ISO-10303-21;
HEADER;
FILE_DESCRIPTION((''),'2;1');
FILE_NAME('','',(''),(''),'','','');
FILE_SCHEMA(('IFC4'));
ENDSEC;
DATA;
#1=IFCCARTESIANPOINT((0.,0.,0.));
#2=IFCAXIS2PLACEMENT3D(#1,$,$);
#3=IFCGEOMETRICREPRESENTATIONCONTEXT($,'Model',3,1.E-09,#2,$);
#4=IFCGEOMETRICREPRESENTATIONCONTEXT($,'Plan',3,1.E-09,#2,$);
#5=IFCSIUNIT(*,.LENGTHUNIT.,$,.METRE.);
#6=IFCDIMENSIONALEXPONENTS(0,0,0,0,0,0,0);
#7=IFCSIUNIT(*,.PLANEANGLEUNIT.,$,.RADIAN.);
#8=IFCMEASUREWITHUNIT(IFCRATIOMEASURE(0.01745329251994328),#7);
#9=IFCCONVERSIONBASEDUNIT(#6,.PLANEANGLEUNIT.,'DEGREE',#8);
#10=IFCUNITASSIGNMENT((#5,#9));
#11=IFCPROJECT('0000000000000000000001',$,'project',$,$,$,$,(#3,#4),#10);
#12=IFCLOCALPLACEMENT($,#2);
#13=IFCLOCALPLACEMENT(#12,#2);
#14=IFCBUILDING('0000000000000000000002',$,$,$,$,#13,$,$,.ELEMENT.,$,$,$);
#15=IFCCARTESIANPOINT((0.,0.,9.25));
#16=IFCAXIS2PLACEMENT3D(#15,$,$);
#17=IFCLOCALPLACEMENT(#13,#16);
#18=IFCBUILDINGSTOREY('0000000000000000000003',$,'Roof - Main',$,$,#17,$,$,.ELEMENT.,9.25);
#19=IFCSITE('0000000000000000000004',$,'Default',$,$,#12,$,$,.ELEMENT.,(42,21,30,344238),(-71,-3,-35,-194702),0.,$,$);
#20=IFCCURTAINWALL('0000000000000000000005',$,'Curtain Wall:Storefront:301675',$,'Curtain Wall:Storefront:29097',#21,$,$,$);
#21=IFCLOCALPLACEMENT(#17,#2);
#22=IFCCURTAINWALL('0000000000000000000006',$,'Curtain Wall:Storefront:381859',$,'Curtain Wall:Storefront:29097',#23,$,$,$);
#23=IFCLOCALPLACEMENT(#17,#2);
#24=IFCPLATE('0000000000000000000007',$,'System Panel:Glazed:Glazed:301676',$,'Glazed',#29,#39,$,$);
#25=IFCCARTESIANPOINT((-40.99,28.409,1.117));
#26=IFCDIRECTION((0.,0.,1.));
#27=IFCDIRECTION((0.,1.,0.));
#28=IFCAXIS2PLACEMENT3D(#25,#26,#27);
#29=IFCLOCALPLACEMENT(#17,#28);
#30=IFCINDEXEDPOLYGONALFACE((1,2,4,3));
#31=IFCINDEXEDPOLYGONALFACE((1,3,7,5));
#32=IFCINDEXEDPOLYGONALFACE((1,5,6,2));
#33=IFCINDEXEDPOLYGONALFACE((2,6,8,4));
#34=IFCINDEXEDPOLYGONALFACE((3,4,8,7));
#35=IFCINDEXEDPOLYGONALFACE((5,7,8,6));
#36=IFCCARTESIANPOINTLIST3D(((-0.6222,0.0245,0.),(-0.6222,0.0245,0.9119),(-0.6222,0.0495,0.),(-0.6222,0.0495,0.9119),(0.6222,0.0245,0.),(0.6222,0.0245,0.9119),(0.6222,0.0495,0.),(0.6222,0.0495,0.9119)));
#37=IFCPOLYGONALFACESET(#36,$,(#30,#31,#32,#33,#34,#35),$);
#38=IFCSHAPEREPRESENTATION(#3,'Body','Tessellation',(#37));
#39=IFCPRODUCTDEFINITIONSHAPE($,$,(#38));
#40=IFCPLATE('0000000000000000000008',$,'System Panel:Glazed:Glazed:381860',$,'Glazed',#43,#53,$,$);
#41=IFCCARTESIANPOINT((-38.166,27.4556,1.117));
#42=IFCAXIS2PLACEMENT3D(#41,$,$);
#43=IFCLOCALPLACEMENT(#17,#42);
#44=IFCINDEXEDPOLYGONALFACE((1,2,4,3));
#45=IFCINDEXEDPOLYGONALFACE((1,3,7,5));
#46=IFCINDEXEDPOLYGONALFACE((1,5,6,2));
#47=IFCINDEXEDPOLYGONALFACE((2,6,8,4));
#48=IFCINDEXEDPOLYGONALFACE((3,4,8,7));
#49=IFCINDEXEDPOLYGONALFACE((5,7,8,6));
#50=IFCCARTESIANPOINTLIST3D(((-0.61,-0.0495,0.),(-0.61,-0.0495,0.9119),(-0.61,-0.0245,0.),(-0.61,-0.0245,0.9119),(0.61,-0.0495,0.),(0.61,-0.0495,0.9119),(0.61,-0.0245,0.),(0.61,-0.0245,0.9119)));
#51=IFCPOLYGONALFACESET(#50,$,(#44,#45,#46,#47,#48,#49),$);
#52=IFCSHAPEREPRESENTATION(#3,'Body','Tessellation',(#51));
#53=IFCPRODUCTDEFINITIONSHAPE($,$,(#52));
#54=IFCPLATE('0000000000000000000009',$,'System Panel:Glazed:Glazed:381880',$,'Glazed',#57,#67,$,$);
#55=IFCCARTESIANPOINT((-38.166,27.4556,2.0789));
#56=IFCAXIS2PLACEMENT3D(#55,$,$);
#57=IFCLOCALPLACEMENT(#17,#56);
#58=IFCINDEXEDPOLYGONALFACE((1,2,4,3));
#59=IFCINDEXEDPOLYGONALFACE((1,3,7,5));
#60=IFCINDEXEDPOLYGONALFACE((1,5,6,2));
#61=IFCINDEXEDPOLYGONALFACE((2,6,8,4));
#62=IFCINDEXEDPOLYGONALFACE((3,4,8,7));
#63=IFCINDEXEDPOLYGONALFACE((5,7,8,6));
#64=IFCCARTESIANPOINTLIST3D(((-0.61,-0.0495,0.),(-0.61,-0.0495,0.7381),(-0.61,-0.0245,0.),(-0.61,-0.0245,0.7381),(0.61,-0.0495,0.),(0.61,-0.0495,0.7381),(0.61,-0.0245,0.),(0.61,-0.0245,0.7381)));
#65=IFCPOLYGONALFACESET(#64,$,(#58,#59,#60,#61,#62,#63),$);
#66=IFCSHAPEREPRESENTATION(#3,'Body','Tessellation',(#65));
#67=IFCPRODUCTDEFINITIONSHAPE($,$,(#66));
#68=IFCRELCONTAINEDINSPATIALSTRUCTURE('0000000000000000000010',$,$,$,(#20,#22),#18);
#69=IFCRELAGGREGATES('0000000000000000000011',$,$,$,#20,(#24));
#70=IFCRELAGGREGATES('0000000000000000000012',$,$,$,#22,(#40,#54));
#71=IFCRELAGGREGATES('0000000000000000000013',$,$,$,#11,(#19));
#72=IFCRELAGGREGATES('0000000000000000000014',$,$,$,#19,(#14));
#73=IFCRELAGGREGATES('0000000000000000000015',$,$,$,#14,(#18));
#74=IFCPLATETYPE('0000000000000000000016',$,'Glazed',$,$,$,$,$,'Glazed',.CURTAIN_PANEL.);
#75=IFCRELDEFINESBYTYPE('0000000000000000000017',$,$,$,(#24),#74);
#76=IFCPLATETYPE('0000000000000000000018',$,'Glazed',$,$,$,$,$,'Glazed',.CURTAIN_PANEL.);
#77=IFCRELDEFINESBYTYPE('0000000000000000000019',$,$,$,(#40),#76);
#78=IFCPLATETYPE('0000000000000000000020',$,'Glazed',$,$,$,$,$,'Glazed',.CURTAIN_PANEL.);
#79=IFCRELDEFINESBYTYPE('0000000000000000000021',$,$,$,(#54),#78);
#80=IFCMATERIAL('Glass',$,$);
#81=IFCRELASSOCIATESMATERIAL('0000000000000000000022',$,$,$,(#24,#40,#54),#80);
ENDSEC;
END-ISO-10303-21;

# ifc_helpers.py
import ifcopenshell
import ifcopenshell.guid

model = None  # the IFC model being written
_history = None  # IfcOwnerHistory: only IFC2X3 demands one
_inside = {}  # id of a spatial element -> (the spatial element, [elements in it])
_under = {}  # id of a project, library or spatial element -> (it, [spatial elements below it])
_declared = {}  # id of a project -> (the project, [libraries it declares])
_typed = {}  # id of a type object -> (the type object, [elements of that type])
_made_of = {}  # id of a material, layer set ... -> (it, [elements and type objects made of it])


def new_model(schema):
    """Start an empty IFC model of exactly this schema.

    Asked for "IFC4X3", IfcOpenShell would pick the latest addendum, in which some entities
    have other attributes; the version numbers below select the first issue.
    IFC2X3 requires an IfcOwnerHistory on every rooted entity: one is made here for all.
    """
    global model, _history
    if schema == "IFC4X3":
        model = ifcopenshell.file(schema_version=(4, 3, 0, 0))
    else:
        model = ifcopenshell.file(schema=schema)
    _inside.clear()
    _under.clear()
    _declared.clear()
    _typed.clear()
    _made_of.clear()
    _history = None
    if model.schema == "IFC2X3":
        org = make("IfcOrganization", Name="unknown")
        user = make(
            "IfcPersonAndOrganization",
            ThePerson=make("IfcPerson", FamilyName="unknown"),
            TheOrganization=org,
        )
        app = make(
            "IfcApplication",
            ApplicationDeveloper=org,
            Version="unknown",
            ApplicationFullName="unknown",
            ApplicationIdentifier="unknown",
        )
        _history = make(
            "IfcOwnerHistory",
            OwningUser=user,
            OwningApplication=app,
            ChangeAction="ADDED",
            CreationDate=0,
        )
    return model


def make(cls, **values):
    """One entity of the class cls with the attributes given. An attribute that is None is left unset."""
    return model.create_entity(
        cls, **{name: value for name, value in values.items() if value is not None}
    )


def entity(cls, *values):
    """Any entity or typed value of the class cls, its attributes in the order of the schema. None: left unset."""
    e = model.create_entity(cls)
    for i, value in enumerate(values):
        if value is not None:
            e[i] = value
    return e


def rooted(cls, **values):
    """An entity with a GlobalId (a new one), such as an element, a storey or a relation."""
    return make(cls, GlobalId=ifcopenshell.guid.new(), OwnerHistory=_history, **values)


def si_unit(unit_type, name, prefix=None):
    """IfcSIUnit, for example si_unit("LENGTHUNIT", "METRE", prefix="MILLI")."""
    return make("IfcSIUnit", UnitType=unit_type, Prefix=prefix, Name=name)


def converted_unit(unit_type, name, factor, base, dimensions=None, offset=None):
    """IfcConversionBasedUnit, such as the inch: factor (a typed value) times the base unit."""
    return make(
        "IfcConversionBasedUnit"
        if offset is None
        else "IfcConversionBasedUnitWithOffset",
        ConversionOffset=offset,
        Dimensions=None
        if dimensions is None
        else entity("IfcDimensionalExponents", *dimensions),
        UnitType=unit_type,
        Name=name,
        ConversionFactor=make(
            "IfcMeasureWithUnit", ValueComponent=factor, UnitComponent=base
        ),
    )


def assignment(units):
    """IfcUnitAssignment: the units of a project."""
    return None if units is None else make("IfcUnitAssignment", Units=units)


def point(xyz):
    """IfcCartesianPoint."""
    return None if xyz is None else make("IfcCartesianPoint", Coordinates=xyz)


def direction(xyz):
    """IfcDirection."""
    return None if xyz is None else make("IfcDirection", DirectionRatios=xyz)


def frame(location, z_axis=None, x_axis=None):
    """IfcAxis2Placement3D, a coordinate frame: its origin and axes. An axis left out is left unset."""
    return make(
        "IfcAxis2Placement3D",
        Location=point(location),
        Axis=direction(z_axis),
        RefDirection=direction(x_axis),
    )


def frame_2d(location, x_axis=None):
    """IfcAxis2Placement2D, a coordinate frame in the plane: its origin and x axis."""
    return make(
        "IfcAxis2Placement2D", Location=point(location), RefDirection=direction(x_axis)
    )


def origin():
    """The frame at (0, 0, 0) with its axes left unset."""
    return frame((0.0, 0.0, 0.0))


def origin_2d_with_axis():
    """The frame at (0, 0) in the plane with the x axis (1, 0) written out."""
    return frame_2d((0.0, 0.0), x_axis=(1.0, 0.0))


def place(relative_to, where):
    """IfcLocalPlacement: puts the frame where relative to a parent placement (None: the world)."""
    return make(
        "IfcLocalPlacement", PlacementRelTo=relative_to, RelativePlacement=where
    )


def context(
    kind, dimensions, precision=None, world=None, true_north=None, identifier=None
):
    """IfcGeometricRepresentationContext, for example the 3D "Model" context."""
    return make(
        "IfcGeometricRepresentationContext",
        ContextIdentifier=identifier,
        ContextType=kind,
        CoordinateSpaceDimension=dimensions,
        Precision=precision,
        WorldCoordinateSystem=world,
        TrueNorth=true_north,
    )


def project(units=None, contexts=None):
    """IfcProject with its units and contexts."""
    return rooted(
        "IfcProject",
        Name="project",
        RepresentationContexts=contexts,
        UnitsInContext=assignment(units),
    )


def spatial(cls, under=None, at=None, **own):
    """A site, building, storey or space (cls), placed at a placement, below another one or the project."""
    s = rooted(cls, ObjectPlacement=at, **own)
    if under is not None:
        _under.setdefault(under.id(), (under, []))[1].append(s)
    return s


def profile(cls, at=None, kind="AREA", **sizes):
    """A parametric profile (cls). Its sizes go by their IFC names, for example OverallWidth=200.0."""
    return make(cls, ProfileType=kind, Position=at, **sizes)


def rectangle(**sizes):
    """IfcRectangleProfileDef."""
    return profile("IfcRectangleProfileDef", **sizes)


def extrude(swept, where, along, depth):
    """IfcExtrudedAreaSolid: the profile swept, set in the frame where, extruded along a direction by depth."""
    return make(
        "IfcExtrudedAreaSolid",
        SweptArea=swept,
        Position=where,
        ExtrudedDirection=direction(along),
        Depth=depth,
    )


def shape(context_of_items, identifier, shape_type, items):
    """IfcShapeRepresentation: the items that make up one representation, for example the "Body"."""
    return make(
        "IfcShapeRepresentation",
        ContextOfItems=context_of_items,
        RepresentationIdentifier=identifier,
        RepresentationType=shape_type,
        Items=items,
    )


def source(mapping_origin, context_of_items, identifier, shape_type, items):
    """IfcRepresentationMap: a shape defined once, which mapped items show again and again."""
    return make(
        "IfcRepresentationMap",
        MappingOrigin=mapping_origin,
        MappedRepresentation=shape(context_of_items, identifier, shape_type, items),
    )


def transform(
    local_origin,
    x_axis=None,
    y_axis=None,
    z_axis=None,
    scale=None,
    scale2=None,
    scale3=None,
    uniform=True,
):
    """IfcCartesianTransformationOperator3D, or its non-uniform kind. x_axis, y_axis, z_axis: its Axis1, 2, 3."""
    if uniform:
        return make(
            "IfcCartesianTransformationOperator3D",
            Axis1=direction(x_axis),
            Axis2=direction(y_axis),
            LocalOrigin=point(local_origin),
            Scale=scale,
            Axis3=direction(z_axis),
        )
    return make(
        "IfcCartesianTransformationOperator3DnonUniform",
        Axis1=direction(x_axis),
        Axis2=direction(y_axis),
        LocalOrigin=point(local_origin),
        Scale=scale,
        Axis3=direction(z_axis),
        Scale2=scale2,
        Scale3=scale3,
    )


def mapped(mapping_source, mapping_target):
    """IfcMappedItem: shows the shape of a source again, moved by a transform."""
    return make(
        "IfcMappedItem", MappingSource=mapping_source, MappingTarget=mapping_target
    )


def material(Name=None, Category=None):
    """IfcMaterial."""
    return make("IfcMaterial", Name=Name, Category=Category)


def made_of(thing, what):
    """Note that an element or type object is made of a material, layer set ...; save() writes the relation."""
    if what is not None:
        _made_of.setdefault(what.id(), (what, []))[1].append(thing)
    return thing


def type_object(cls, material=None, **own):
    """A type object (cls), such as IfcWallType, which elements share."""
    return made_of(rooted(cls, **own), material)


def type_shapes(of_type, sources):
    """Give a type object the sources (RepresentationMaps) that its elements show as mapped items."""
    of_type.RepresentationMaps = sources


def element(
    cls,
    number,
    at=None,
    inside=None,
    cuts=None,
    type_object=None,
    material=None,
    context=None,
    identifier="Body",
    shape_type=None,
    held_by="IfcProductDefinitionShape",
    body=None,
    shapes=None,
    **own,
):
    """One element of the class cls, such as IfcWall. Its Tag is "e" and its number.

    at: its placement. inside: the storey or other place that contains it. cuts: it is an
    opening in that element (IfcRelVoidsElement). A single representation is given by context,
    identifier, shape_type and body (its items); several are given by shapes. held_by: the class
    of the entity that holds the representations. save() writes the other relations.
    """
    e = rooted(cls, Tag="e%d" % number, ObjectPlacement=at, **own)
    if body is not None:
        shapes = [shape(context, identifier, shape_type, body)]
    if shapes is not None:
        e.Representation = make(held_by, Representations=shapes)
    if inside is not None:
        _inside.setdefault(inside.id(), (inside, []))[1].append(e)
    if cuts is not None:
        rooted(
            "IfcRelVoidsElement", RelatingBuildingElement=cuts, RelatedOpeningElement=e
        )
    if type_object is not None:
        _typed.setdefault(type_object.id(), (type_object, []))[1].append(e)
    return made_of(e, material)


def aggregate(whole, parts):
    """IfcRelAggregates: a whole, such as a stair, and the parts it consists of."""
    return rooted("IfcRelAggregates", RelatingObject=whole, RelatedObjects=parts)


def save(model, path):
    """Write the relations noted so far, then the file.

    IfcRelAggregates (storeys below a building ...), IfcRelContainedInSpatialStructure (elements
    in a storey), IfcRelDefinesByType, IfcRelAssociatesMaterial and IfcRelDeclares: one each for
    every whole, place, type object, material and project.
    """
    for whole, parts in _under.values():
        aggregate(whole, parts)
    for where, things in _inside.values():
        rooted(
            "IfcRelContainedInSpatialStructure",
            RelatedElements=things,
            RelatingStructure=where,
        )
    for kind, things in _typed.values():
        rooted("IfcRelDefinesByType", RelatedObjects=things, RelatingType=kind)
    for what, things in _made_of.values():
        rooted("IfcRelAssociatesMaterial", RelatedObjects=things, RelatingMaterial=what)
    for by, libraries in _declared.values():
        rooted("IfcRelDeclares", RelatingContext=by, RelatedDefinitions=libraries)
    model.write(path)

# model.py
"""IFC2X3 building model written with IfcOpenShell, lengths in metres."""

from ifc_helpers import new_model, entity, si_unit, converted_unit, frame, origin, origin_2d_with_axis, place, context, project, spatial, rectangle, extrude, source, transform, mapped, material, type_object, type_shapes, element, aggregate, save


model = new_model("IFC2X3")

# Units and contexts
model_context = context("Model", 3, precision=1e-09, world=origin())
plan_context = context("Plan", 3, precision=1e-09, world=origin())
ifc_project = project(units=[si_unit("LENGTHUNIT", "METRE"), converted_unit("PLANEANGLEUNIT", "DEGREE", entity("IfcRatioMeasure", 0.01745329251994328), si_unit("PLANEANGLEUNIT", "RADIAN"), dimensions=[0, 0, 0, 0, 0, 0, 0])], contexts=[model_context, plan_context])

# Site, building, storey
site_placement = place(None, origin())
site = spatial("IfcSite", under=ifc_project, at=site_placement, Name="Default", CompositionType="ELEMENT", RefLatitude=(42, 21, 30, 344238), RefLongitude=(-71, -3, -35, -194702), RefElevation=0.0)
building_placement = place(site_placement, origin())
building = spatial("IfcBuilding", under=site, at=building_placement, CompositionType="ELEMENT")
storey_placement = place(building_placement, frame((0.0, 0.0, 9.25)))
storey = spatial("IfcBuildingStorey", under=building, at=storey_placement, Name="Roof - Main", CompositionType="ELEMENT", Elevation=9.25)

# Curtain walls
curtain_wall_1_placement = place(storey_placement, origin())
curtain_wall_1 = element("IfcCurtainWall", 1, at=curtain_wall_1_placement, inside=storey, Name="Curtain Wall:Storefront:301675", ObjectType="Curtain Wall:Storefront:29097")
curtain_wall_2_placement = place(storey_placement, origin())
curtain_wall_2 = element("IfcCurtainWall", 2, at=curtain_wall_2_placement, inside=storey, Name="Curtain Wall:Storefront:381859", ObjectType="Curtain Wall:Storefront:29097")

# Plates
ifc_material_1 = material(Name="Glass")
plate_type_1 = type_object("IfcPlateType", Name="Glazed", ElementType="Glazed", PredefinedType="CURTAIN_PANEL")
shared_shape_1 = source(origin(), model_context, "Body", "SweptSolid", [
    extrude(rectangle(XDim=0.025, YDim=1.2444, at=origin_2d_with_axis()), frame((0.0, 0.037, 0.0), z_axis=(0.0, 0.0, 1.0), x_axis=(0.0, 1.0, 0.0)), (0.0, 0.0, 1.0), 0.9119),
])
type_shapes(plate_type_1, [shared_shape_1])
plate_1_placement = place(storey_placement, frame((-40.99, 28.409, 1.117), z_axis=(0.0, 0.0, 1.0), x_axis=(0.0, 1.0, 0.0)))
plate_1 = element("IfcPlate", 3, at=plate_1_placement, type_object=plate_type_1, material=ifc_material_1, Name="System Panel:Glazed:Glazed:301676", ObjectType="Glazed", context=model_context, shape_type="MappedRepresentation", body=[
    mapped(shared_shape_1, transform((0.0, 0.0, 0.0), scale=1.0)),
])
aggregate(curtain_wall_1, [plate_1])
plate_type_2 = type_object("IfcPlateType", Name="Glazed", ElementType="Glazed", PredefinedType="CURTAIN_PANEL")
shared_shape_2 = source(origin(), model_context, "Body", "SweptSolid", [
    extrude(rectangle(XDim=0.025, YDim=1.22, at=origin_2d_with_axis()), frame((0.0, -0.037, 0.0), z_axis=(0.0, 0.0, 1.0), x_axis=(0.0, 1.0, 0.0)), (0.0, 0.0, 1.0), 0.9119),
])
type_shapes(plate_type_2, [shared_shape_2])
plate_2_placement = place(storey_placement, frame((-38.166, 27.4556, 1.117)))
plate_2 = element("IfcPlate", 4, at=plate_2_placement, type_object=plate_type_2, material=ifc_material_1, Name="System Panel:Glazed:Glazed:381860", ObjectType="Glazed", context=model_context, shape_type="MappedRepresentation", body=[
    mapped(shared_shape_2, transform((0.0, 0.0, 0.0), scale=1.0)),
])
plate_type_3 = type_object("IfcPlateType", Name="Glazed", ElementType="Glazed", PredefinedType="CURTAIN_PANEL")
shared_shape_3 = source(origin(), model_context, "Body", "SweptSolid", [
    extrude(rectangle(XDim=0.025, YDim=1.22, at=origin_2d_with_axis()), frame((0.0, -0.037, 0.0), z_axis=(0.0, 0.0, 1.0), x_axis=(0.0, 1.0, 0.0)), (0.0, 0.0, 1.0), 0.7381),
])
type_shapes(plate_type_3, [shared_shape_3])
plate_3_placement = place(storey_placement, frame((-38.166, 27.4556, 2.0789)))
plate_3 = element("IfcPlate", 5, at=plate_3_placement, type_object=plate_type_3, material=ifc_material_1, Name="System Panel:Glazed:Glazed:381880", ObjectType="Glazed", context=model_context, shape_type="MappedRepresentation", body=[
    mapped(shared_shape_3, transform((0.0, 0.0, 0.0), scale=1.0)),
])
aggregate(curtain_wall_2, [plate_2, plate_3])

save(model, "model.ifc")
